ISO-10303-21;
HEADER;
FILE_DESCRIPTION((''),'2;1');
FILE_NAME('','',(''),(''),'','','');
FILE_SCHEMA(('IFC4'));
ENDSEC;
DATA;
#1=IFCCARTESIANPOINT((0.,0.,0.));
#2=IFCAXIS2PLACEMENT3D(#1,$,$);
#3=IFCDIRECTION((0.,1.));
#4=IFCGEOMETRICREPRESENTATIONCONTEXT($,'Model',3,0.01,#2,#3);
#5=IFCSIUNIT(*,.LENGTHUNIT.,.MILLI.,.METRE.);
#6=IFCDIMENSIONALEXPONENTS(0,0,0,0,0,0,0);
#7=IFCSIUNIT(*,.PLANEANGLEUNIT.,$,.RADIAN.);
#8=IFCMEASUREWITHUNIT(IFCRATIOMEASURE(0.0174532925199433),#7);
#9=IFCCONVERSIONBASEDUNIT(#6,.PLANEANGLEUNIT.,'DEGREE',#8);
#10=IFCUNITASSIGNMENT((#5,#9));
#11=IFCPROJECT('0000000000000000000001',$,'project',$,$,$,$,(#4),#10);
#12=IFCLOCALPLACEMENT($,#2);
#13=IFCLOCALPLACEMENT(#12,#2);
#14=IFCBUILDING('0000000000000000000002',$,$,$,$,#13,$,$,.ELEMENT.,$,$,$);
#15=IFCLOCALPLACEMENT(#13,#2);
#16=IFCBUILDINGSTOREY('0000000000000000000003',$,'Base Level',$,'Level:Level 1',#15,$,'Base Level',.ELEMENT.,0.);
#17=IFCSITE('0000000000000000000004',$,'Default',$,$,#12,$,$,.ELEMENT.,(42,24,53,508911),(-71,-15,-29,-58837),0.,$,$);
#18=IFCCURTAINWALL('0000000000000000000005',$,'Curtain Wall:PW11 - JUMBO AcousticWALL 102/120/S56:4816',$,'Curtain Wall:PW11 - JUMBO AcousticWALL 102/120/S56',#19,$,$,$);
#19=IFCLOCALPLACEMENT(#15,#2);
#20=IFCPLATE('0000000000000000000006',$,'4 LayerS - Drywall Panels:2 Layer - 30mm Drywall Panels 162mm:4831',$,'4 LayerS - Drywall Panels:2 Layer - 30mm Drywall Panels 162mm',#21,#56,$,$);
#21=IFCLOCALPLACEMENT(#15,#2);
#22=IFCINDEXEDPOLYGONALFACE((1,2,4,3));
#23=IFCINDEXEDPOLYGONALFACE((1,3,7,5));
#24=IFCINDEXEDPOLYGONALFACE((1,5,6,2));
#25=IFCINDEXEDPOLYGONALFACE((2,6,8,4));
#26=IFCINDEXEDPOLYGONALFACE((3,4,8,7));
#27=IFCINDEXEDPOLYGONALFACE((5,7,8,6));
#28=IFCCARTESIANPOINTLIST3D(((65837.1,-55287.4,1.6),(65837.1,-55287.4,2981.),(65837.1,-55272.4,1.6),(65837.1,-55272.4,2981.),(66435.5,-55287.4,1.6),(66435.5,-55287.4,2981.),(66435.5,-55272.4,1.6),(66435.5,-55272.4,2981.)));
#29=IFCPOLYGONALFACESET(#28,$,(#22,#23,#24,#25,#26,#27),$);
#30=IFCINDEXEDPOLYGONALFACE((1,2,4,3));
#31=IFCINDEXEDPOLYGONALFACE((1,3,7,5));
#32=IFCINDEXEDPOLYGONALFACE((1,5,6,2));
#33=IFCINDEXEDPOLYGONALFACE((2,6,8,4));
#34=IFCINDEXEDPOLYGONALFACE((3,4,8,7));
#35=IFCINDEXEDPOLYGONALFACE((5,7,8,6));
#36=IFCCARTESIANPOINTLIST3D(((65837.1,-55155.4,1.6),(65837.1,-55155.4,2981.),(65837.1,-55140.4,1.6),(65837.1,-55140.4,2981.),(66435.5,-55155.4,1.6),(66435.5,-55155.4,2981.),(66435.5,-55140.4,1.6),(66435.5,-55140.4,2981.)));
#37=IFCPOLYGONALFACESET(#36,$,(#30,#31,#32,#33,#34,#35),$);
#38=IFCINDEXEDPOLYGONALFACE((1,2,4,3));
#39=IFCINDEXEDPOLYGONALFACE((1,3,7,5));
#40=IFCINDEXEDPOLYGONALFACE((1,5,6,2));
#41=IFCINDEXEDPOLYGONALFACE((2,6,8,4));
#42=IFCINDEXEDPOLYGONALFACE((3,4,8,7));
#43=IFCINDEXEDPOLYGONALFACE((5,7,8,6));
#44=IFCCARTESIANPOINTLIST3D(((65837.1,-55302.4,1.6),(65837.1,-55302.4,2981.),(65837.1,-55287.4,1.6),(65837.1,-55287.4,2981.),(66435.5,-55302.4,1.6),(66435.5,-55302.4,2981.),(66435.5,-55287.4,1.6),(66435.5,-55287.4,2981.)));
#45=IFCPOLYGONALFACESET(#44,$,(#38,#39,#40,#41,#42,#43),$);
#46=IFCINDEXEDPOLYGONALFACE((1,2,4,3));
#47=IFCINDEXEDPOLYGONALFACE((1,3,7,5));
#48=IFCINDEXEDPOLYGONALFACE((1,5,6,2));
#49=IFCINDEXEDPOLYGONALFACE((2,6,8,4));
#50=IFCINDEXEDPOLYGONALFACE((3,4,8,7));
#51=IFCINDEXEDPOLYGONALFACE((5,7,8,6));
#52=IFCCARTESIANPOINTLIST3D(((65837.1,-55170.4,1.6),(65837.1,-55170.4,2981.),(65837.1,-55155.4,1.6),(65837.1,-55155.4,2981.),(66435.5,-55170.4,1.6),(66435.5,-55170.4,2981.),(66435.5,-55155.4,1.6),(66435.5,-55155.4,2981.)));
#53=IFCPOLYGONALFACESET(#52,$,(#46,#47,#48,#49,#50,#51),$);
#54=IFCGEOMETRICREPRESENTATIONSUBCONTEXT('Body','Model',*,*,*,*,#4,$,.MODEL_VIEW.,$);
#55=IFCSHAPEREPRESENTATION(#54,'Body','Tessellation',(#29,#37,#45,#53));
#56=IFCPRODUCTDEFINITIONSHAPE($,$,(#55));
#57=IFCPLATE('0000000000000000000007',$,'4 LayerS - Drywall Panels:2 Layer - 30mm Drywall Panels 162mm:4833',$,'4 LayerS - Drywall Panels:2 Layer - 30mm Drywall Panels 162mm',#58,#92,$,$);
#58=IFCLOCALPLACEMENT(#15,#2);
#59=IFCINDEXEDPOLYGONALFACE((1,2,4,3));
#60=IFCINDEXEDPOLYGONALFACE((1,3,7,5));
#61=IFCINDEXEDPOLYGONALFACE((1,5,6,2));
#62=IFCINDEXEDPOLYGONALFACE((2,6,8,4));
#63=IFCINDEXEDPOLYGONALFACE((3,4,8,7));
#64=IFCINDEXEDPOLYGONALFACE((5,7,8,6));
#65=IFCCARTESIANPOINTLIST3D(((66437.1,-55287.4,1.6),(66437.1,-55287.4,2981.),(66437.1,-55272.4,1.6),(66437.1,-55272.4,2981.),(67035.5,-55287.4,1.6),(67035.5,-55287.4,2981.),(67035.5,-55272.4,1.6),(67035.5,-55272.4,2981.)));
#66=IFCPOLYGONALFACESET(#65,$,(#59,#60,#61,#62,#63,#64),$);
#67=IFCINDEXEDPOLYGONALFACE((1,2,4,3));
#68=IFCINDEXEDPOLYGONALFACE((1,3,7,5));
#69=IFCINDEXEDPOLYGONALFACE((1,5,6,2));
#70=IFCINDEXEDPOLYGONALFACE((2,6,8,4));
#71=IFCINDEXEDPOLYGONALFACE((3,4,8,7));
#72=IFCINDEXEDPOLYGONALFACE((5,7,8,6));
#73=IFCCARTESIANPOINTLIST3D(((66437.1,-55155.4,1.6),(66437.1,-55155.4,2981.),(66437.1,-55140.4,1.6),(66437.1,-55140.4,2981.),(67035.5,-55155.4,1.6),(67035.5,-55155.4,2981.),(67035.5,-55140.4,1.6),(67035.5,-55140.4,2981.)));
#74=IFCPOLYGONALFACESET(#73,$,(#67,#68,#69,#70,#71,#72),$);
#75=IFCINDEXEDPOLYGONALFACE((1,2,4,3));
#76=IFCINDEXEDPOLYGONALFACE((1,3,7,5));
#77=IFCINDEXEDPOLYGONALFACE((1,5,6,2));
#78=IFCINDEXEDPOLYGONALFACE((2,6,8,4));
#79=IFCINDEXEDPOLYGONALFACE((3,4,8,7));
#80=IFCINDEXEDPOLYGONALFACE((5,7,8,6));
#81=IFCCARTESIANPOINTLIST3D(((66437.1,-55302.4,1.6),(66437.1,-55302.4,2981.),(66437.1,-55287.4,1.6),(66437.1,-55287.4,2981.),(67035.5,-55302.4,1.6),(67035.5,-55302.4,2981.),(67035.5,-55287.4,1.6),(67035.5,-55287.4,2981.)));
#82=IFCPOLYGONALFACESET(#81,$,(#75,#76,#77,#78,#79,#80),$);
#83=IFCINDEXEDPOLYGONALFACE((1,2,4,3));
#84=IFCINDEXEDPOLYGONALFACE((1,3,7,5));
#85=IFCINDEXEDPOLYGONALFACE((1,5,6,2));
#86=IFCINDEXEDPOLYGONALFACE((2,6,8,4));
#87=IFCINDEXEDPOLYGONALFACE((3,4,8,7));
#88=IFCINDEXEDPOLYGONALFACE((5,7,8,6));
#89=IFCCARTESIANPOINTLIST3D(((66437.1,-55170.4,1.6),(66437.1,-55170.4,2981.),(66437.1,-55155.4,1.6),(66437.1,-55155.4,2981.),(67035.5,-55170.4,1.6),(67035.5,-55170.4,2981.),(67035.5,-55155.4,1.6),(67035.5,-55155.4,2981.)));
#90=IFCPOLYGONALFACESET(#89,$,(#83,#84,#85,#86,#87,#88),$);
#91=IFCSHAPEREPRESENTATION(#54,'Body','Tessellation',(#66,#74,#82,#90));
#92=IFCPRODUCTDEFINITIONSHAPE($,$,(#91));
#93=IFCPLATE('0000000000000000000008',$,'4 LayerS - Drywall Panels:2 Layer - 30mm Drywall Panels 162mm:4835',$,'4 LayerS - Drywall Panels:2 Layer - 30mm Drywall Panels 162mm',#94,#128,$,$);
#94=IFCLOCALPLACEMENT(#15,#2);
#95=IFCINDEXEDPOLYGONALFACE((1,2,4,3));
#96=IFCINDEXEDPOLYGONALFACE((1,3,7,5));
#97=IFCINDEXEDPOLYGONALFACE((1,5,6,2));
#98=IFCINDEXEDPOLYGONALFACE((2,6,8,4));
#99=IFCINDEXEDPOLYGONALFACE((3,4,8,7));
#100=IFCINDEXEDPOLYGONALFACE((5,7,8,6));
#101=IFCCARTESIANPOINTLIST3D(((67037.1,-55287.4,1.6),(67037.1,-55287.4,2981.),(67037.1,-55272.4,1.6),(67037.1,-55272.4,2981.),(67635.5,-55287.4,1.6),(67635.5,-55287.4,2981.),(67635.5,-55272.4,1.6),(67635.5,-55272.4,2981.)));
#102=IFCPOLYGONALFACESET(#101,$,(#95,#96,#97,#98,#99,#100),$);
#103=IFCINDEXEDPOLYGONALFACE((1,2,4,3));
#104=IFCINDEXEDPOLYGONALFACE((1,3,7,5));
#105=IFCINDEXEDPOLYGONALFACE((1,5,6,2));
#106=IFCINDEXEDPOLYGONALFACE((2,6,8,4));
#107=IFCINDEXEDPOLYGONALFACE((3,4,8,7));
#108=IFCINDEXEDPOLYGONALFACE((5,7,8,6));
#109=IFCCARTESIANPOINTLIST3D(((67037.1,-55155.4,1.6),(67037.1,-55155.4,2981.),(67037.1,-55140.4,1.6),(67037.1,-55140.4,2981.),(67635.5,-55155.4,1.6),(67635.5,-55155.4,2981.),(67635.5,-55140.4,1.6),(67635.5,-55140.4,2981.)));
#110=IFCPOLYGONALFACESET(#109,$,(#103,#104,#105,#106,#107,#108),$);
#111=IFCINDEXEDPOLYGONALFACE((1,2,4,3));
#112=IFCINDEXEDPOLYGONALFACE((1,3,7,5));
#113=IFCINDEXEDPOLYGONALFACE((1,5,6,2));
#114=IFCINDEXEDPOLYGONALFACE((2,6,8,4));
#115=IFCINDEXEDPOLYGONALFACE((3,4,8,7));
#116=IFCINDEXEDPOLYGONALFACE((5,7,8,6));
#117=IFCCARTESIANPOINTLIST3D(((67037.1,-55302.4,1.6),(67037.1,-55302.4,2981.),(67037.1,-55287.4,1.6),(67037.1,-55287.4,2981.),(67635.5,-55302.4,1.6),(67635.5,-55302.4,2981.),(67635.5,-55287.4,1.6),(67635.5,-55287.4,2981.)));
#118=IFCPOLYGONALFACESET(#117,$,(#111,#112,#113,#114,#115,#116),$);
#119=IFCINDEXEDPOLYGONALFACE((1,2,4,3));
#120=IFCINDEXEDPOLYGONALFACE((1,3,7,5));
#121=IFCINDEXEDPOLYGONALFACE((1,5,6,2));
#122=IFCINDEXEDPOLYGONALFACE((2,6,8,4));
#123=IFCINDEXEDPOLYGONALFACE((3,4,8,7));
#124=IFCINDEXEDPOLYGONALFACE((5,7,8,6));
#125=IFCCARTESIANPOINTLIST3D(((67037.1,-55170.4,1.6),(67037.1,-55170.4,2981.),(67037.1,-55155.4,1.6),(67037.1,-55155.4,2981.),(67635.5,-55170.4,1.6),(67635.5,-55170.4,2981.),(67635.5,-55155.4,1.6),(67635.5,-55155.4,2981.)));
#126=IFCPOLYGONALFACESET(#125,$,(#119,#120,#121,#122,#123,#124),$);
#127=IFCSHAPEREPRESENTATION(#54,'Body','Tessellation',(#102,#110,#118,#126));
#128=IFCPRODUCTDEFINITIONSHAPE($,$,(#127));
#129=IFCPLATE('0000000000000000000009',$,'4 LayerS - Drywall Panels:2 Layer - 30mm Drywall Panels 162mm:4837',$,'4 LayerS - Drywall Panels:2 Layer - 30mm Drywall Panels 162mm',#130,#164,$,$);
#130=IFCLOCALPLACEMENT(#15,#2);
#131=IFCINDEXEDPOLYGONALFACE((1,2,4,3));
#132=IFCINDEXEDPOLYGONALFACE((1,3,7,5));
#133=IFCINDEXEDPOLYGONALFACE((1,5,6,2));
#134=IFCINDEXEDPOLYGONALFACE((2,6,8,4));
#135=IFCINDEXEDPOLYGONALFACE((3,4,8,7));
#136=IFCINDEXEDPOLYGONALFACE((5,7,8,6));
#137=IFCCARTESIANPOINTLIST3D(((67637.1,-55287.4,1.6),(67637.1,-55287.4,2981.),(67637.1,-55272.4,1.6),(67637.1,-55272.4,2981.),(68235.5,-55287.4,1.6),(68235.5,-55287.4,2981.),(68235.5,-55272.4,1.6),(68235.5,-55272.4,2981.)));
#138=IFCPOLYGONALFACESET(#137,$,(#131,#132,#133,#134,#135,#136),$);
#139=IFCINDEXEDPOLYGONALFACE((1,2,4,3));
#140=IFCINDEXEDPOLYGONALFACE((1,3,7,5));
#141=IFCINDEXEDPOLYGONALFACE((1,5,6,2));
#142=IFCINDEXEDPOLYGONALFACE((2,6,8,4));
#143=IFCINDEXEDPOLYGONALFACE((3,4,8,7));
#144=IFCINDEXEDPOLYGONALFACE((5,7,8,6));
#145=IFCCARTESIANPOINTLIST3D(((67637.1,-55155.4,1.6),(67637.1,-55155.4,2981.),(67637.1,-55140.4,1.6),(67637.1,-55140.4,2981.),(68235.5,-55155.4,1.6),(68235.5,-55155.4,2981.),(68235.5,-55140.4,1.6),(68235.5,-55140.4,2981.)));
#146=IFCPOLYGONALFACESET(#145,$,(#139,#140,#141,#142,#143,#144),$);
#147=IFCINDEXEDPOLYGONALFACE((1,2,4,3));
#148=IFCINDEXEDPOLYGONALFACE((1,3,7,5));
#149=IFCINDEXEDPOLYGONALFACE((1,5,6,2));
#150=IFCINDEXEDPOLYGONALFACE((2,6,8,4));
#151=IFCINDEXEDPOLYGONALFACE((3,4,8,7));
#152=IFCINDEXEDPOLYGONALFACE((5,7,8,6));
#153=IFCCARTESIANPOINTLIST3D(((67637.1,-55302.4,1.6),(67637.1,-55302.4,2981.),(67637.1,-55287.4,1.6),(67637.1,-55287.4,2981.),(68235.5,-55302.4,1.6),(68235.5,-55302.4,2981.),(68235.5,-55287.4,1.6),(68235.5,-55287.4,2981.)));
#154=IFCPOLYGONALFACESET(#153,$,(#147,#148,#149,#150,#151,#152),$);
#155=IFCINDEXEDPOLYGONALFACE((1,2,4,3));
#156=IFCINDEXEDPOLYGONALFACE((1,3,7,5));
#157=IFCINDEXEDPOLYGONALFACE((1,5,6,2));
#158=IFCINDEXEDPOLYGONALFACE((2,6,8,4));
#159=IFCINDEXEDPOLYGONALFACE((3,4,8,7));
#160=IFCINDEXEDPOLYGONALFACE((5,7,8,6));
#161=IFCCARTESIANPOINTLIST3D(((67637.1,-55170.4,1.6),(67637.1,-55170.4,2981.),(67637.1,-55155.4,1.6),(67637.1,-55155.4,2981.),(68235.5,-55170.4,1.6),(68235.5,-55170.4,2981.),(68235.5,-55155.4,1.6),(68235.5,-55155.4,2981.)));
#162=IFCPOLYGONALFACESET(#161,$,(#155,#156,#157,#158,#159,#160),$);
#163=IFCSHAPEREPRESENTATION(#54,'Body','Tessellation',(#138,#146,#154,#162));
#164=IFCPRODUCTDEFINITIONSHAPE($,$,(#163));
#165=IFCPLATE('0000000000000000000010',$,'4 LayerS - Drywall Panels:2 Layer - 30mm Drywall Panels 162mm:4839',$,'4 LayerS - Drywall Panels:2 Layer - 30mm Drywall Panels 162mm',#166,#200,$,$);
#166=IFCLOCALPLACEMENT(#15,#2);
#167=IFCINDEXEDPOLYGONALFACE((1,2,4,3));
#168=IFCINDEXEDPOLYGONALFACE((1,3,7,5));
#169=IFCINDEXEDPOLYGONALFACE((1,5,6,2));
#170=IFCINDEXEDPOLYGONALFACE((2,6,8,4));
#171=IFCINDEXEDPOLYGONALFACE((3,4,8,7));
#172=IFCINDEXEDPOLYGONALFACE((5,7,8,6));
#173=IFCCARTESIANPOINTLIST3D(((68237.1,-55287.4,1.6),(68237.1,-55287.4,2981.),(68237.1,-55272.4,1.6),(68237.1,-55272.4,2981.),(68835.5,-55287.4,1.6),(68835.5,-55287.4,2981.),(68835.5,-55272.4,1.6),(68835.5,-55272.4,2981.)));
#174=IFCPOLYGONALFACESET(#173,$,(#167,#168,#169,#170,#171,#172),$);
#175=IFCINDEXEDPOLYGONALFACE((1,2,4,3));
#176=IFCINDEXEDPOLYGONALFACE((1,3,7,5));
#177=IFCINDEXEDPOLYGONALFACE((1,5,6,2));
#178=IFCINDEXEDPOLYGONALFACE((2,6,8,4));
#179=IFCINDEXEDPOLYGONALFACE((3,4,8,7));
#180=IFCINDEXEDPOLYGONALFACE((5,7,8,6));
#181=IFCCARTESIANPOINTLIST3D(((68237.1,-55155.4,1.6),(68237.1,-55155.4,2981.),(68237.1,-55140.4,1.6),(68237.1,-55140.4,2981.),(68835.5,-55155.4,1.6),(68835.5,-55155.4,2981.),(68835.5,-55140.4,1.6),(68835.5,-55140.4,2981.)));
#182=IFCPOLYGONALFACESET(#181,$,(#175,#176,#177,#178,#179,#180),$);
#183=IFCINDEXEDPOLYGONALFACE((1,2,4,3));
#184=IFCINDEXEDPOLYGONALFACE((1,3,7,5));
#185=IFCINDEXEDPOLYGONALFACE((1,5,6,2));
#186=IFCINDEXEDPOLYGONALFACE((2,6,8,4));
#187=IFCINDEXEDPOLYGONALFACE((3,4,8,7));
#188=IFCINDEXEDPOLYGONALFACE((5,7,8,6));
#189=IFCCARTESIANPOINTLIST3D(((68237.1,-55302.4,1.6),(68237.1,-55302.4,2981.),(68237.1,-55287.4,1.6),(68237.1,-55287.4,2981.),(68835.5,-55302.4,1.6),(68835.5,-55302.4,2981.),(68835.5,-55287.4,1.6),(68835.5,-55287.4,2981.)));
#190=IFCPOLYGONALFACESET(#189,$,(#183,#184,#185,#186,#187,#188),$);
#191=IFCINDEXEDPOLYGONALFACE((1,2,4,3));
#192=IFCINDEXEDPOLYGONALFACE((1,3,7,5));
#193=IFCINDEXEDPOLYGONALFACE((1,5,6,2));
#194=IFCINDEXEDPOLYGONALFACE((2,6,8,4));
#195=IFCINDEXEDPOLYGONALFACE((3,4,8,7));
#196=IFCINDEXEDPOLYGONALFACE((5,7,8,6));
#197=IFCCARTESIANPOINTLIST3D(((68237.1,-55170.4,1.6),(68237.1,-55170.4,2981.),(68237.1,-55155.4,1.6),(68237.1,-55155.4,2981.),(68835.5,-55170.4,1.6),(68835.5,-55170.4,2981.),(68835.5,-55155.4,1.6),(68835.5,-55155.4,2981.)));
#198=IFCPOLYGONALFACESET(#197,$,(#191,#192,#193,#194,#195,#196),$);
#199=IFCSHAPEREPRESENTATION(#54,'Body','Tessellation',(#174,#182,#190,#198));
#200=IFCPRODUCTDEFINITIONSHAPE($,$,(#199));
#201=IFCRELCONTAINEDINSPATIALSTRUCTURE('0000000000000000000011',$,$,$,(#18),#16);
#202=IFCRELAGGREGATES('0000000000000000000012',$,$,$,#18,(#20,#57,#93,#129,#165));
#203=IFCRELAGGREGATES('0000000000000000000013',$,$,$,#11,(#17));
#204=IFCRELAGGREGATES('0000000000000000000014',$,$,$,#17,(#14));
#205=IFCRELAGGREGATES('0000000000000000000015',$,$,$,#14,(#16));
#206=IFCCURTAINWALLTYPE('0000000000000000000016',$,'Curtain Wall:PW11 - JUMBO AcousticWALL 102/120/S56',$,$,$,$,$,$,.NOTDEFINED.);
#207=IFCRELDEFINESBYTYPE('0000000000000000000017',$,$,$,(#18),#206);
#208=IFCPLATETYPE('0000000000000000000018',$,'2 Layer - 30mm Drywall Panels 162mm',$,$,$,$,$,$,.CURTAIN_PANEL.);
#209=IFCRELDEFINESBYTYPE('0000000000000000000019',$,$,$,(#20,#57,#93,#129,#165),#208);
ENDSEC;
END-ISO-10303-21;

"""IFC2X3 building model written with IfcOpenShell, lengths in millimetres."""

from ifc_helpers import new_model, entity, si_unit, converted_unit, direction, frame, frame_2d, origin, origin_2d_with_axis, place, context, subcontext, project, spatial, rectangle, extrude, source, transform, mapped, type_object, type_shapes, element, aggregate, save


model = new_model("IFC2X3")

# Units and contexts
model_context = context("Model", 3, precision=0.01, world=origin(), true_north=direction((0.0, 1.0)))
body_context = subcontext(model_context, "Body", "Model", "MODEL_VIEW")
ifc_project = project(units=[si_unit("LENGTHUNIT", "METRE", prefix="MILLI"), converted_unit("PLANEANGLEUNIT", "DEGREE", entity("IfcRatioMeasure", 0.0174532925199433), si_unit("PLANEANGLEUNIT", "RADIAN"), dimensions=[0, 0, 0, 0, 0, 0, 0])], contexts=[model_context])

# Site, building, storey
site_placement = place(None, origin())
site = spatial("IfcSite", under=ifc_project, at=site_placement, Name="Default", CompositionType="ELEMENT", RefLatitude=(42, 24, 53, 508911), RefLongitude=(-71, -15, -29, -58837), RefElevation=0.0)
building_placement = place(site_placement, origin())
building = spatial("IfcBuilding", under=site, at=building_placement, CompositionType="ELEMENT")
storey_placement = place(building_placement, origin())
storey = spatial("IfcBuildingStorey", under=building, at=storey_placement, Name="Base Level", ObjectType="Level:Level 1", LongName="Base Level", CompositionType="ELEMENT", Elevation=0.0)

# Curtain wall, plates
curtain_wall_type = type_object("IfcCurtainWallType", Name="Curtain Wall:PW11 - JUMBO AcousticWALL 102/120/S56", PredefinedType="NOTDEFINED")
curtain_wall_placement = place(building_placement, origin())
curtain_wall = element("IfcCurtainWall", 1, at=curtain_wall_placement, inside=storey, type_object=curtain_wall_type, Name="Curtain Wall:PW11 - JUMBO AcousticWALL 102/120/S56:4816", ObjectType="Curtain Wall:PW11 - JUMBO AcousticWALL 102/120/S56")
plate_type = type_object("IfcPlateType", Name="2 Layer - 30mm Drywall Panels 162mm", PredefinedType="CURTAIN_PANEL")
shared_shape_1 = source(origin(), body_context, "Body", "SweptSolid", [
    extrude(rectangle(XDim=15.0, YDim=598.4, at=origin_2d_with_axis()), frame((0.0, -58.5, 0.0), z_axis=(0.0, 0.0, 1.0), x_axis=(0.0, 1.0, 0.0)), (0.0, 0.0, 1.0), 2979.4),
    extrude(rectangle(XDim=15.0, YDim=598.4, at=frame_2d((0.0, 0.0), x_axis=(1.0, 0.0))), frame((0.0, 73.5, 0.0), z_axis=(0.0, 0.0, 1.0), x_axis=(0.0, 1.0, 0.0)), (0.0, 0.0, 1.0), 2979.4),
    extrude(rectangle(XDim=598.4, YDim=15.0, at=origin_2d_with_axis()), frame((0.0, -73.5, 0.0), z_axis=(0.0, 0.0, 1.0), x_axis=(-1.0, 0.0, 0.0)), (0.0, 0.0, 1.0), 2979.4),
    extrude(rectangle(XDim=15.0, YDim=598.4, at=frame_2d((0.0, 0.0), x_axis=(1.0, 0.0))), frame((0.0, 58.5, 0.0), z_axis=(0.0, 0.0, 1.0), x_axis=(0.0, 1.0, 0.0)), (0.0, 0.0, 1.0), 2979.4),
])
type_shapes(plate_type, [shared_shape_1])
plate_1_placement = place(curtain_wall_placement, frame((66136.3, -55221.4, 1.6)))
plate_1 = element("IfcPlate", 2, at=plate_1_placement, type_object=plate_type, Name="4 LayerS - Drywall Panels:2 Layer - 30mm Drywall Panels 162mm:4831", ObjectType="4 LayerS - Drywall Panels:2 Layer - 30mm Drywall Panels 162mm", context=body_context, shape_type="MappedRepresentation", body=[
    mapped(shared_shape_1, transform((0.0, 0.0, 0.0), scale=1.0)),
])
plate_2_placement = place(curtain_wall_placement, frame((66736.3, -55221.4, 1.6)))
plate_2 = element("IfcPlate", 3, at=plate_2_placement, type_object=plate_type, Name="4 LayerS - Drywall Panels:2 Layer - 30mm Drywall Panels 162mm:4833", ObjectType="4 LayerS - Drywall Panels:2 Layer - 30mm Drywall Panels 162mm", context=body_context, shape_type="MappedRepresentation", body=[
    mapped(shared_shape_1, transform((0.0, 0.0, 0.0), scale=1.0)),
])
plate_3_placement = place(curtain_wall_placement, frame((67336.3, -55221.4, 1.6)))
plate_3 = element("IfcPlate", 4, at=plate_3_placement, type_object=plate_type, Name="4 LayerS - Drywall Panels:2 Layer - 30mm Drywall Panels 162mm:4835", ObjectType="4 LayerS - Drywall Panels:2 Layer - 30mm Drywall Panels 162mm", context=body_context, shape_type="MappedRepresentation", body=[
    mapped(shared_shape_1, transform((0.0, 0.0, 0.0), scale=1.0)),
])
plate_4_placement = place(curtain_wall_placement, frame((67936.3, -55221.4, 1.6)))
plate_4 = element("IfcPlate", 5, at=plate_4_placement, type_object=plate_type, Name="4 LayerS - Drywall Panels:2 Layer - 30mm Drywall Panels 162mm:4837", ObjectType="4 LayerS - Drywall Panels:2 Layer - 30mm Drywall Panels 162mm", context=body_context, shape_type="MappedRepresentation", body=[
    mapped(shared_shape_1, transform((0.0, 0.0, 0.0), scale=1.0)),
])
plate_5_placement = place(curtain_wall_placement, frame((68536.3, -55221.4, 1.6)))
plate_5 = element("IfcPlate", 6, at=plate_5_placement, type_object=plate_type, Name="4 LayerS - Drywall Panels:2 Layer - 30mm Drywall Panels 162mm:4839", ObjectType="4 LayerS - Drywall Panels:2 Layer - 30mm Drywall Panels 162mm", context=body_context, shape_type="MappedRepresentation", body=[
    mapped(shared_shape_1, transform((0.0, 0.0, 0.0), scale=1.0)),
])
aggregate(curtain_wall, [plate_1, plate_2, plate_3, plate_4, plate_5])

save(model, "model.ifc")
